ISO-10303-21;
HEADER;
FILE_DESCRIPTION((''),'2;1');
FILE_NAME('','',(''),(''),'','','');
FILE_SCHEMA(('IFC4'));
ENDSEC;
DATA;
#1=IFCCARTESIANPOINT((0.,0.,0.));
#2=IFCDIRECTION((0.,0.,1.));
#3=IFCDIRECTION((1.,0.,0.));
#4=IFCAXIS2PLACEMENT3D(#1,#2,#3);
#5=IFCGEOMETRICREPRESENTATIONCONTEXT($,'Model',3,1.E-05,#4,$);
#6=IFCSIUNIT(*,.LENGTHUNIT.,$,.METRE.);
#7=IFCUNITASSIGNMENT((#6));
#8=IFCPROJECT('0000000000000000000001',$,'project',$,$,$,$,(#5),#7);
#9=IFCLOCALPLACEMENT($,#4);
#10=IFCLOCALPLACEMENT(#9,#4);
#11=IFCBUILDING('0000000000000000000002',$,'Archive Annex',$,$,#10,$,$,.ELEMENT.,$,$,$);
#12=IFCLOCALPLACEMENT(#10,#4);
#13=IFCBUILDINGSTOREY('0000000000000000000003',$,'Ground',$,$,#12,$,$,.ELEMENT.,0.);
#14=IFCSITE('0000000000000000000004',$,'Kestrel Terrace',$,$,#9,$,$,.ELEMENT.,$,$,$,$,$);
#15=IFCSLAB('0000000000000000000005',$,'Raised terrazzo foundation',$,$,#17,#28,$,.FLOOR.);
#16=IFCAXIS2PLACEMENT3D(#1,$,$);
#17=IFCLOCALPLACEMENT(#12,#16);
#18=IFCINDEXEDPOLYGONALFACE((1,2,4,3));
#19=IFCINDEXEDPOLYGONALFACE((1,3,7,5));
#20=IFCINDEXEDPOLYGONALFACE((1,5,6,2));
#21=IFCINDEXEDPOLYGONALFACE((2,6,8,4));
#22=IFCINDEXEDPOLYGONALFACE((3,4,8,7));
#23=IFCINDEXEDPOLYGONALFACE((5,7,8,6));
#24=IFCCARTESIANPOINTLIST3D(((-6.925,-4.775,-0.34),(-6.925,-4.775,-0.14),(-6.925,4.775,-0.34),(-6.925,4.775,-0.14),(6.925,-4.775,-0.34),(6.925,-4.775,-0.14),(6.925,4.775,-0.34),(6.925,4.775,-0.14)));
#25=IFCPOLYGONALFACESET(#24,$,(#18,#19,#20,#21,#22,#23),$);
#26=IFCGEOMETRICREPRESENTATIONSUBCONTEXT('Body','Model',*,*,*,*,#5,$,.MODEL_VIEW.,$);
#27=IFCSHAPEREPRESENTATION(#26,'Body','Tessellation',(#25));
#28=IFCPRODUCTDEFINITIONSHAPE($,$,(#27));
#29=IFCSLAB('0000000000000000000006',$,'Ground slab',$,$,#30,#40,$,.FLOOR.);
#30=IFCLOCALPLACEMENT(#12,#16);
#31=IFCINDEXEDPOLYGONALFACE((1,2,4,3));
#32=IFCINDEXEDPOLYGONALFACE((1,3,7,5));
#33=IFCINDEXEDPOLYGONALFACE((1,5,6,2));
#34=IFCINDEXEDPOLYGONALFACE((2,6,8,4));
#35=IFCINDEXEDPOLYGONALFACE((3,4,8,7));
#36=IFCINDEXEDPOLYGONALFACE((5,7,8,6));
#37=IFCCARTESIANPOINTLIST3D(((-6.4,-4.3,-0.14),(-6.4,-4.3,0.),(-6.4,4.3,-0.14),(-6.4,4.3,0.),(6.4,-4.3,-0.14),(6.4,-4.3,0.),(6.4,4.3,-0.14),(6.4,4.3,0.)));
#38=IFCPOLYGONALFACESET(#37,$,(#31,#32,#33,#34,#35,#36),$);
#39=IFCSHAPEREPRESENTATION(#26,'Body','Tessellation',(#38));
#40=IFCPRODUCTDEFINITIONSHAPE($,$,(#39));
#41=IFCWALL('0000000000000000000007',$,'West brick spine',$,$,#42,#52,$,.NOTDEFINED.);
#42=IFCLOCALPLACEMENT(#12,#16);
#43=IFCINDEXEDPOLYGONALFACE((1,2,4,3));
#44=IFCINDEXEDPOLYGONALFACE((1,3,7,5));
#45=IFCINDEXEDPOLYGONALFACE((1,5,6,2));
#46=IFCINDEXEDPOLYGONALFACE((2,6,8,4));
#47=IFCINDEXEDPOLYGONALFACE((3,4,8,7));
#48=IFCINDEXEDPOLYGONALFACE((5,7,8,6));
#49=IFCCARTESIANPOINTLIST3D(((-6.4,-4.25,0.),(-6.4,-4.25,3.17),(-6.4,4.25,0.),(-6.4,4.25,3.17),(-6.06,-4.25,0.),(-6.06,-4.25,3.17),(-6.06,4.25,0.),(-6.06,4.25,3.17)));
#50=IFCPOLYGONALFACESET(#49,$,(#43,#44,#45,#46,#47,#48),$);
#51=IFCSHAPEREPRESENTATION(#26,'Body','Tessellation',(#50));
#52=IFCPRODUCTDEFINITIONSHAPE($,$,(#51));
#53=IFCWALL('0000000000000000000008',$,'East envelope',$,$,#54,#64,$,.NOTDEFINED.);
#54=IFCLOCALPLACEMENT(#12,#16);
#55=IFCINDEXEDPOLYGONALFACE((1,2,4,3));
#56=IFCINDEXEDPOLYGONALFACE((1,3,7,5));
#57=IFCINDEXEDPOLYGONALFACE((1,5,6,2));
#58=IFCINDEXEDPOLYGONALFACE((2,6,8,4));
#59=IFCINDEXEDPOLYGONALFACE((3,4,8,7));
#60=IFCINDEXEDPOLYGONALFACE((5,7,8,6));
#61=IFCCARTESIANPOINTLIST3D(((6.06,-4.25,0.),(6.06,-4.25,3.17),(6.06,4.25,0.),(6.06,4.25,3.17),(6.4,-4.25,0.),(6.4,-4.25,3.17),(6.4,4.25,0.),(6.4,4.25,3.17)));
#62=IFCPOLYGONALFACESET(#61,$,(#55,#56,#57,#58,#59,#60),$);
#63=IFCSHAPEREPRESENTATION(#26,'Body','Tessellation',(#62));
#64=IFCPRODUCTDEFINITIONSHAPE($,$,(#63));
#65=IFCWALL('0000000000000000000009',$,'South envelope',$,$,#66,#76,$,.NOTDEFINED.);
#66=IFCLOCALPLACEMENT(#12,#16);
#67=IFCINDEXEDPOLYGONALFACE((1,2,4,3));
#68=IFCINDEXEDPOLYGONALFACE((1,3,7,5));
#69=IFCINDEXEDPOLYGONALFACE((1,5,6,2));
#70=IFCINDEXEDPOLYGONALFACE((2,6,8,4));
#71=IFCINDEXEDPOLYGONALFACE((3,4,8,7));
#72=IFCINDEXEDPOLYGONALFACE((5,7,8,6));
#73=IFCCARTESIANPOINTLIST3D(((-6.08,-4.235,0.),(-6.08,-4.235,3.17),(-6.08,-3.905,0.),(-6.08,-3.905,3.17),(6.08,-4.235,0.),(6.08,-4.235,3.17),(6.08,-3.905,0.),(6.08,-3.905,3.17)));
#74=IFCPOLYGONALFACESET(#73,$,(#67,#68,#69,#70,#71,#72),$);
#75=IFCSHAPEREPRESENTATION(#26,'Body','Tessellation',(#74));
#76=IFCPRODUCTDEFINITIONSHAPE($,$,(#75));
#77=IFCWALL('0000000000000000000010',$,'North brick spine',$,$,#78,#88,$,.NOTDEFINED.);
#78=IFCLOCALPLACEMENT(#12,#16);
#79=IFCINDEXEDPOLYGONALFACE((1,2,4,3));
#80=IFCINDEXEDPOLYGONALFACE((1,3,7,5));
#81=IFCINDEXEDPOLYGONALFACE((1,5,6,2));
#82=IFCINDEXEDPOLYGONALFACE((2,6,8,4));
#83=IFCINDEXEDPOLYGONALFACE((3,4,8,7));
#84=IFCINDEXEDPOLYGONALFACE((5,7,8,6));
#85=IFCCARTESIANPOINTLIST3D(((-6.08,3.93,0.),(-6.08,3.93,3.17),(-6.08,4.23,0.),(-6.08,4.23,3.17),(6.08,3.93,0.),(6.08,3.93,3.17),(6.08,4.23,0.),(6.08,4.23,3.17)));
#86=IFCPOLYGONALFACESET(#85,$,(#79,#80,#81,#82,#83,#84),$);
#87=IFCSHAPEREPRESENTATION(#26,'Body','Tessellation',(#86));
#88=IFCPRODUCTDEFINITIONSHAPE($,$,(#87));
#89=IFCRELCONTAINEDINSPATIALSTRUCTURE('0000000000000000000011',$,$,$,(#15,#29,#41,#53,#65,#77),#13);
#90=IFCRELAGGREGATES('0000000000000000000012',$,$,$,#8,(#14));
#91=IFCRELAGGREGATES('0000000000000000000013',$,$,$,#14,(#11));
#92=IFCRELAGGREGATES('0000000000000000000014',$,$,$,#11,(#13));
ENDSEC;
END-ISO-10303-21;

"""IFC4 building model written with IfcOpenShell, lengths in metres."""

from ifc_helpers import new_model, si_unit, frame, origin_with_axes, origin_2d, place, context, subcontext, project, spatial, rectangle, extrude, element, save


model = new_model("IFC4")

# Units and contexts
model_context = context("Model", 3, precision=1e-05, world=origin_with_axes())
body_context = subcontext(model_context, "Body", "Model", "MODEL_VIEW")
ifc_project = project(units=[si_unit("LENGTHUNIT", "METRE")], contexts=[model_context])

# Site, building, storey
site_placement = place(None, origin_with_axes())
site = spatial("IfcSite", under=ifc_project, at=site_placement, Name="Kestrel Terrace", CompositionType="ELEMENT")
building_placement = place(site_placement, origin_with_axes())
building = spatial("IfcBuilding", under=site, at=building_placement, Name="Archive Annex", CompositionType="ELEMENT")
storey_placement = place(building_placement, origin_with_axes())
storey = spatial("IfcBuildingStorey", under=building, at=storey_placement, Name="Ground", CompositionType="ELEMENT", Elevation=0.0)

# Slabs
slab_1_placement = place(storey_placement, frame((0.0, 0.0, -0.34), z_axis=(0.0, 0.0, 1.0), x_axis=(1.0, 0.0, 0.0)))
element("IfcSlab", 1, at=slab_1_placement, inside=storey, Name="Raised terrazzo foundation", PredefinedType="FLOOR", context=body_context, shape_type="SweptSolid", body=[
    extrude(rectangle(XDim=13.85, YDim=9.55, at=origin_2d()), origin_with_axes(), (0.0, 0.0, 1.0), 0.2),
])
slab_2_placement = place(storey_placement, frame((0.0, 0.0, -0.14), z_axis=(0.0, 0.0, 1.0), x_axis=(1.0, 0.0, 0.0)))
element("IfcSlab", 2, at=slab_2_placement, inside=storey, Name="Ground slab", PredefinedType="FLOOR", context=body_context, shape_type="SweptSolid", body=[
    extrude(rectangle(XDim=12.8, YDim=8.6, at=origin_2d()), origin_with_axes(), (0.0, 0.0, 1.0), 0.14),
])

# Walls
for number, where, z_axis, x_axis, name in (
    (3, (-6.23, 0.0, 0.0), (0.0, 0.0, 1.0), (1.0, 0.0, 0.0), "West brick spine"),
    (4, (6.23, 0.0, 0.0), (0.0, 0.0, 1.0), (1.0, 0.0, 0.0), "East envelope"),
):
    element("IfcWall", number, at=place(storey_placement, frame(where, z_axis=z_axis, x_axis=x_axis)), inside=storey, Name=name, PredefinedType="NOTDEFINED", context=body_context, shape_type="SweptSolid", body=[
        extrude(rectangle(XDim=0.34, YDim=8.5, at=origin_2d()), origin_with_axes(), (0.0, 0.0, 1.0), 3.17),
    ])
wall_1_placement = place(storey_placement, frame((0.0, -4.07, 0.0), z_axis=(0.0, 0.0, 1.0), x_axis=(1.0, 0.0, 0.0)))
element("IfcWall", 5, at=wall_1_placement, inside=storey, Name="South envelope", PredefinedType="NOTDEFINED", context=body_context, shape_type="SweptSolid", body=[
    extrude(rectangle(XDim=12.16, YDim=0.33, at=origin_2d()), origin_with_axes(), (0.0, 0.0, 1.0), 3.17),
])
wall_2_placement = place(storey_placement, frame((0.0, 4.08, 0.0), z_axis=(0.0, 0.0, 1.0), x_axis=(1.0, 0.0, 0.0)))
element("IfcWall", 6, at=wall_2_placement, inside=storey, Name="North brick spine", PredefinedType="NOTDEFINED", context=body_context, shape_type="SweptSolid", body=[
    extrude(rectangle(XDim=12.16, YDim=0.3, at=origin_2d()), origin_with_axes(), (0.0, 0.0, 1.0), 3.17),
])

save(model, "model.ifc")
